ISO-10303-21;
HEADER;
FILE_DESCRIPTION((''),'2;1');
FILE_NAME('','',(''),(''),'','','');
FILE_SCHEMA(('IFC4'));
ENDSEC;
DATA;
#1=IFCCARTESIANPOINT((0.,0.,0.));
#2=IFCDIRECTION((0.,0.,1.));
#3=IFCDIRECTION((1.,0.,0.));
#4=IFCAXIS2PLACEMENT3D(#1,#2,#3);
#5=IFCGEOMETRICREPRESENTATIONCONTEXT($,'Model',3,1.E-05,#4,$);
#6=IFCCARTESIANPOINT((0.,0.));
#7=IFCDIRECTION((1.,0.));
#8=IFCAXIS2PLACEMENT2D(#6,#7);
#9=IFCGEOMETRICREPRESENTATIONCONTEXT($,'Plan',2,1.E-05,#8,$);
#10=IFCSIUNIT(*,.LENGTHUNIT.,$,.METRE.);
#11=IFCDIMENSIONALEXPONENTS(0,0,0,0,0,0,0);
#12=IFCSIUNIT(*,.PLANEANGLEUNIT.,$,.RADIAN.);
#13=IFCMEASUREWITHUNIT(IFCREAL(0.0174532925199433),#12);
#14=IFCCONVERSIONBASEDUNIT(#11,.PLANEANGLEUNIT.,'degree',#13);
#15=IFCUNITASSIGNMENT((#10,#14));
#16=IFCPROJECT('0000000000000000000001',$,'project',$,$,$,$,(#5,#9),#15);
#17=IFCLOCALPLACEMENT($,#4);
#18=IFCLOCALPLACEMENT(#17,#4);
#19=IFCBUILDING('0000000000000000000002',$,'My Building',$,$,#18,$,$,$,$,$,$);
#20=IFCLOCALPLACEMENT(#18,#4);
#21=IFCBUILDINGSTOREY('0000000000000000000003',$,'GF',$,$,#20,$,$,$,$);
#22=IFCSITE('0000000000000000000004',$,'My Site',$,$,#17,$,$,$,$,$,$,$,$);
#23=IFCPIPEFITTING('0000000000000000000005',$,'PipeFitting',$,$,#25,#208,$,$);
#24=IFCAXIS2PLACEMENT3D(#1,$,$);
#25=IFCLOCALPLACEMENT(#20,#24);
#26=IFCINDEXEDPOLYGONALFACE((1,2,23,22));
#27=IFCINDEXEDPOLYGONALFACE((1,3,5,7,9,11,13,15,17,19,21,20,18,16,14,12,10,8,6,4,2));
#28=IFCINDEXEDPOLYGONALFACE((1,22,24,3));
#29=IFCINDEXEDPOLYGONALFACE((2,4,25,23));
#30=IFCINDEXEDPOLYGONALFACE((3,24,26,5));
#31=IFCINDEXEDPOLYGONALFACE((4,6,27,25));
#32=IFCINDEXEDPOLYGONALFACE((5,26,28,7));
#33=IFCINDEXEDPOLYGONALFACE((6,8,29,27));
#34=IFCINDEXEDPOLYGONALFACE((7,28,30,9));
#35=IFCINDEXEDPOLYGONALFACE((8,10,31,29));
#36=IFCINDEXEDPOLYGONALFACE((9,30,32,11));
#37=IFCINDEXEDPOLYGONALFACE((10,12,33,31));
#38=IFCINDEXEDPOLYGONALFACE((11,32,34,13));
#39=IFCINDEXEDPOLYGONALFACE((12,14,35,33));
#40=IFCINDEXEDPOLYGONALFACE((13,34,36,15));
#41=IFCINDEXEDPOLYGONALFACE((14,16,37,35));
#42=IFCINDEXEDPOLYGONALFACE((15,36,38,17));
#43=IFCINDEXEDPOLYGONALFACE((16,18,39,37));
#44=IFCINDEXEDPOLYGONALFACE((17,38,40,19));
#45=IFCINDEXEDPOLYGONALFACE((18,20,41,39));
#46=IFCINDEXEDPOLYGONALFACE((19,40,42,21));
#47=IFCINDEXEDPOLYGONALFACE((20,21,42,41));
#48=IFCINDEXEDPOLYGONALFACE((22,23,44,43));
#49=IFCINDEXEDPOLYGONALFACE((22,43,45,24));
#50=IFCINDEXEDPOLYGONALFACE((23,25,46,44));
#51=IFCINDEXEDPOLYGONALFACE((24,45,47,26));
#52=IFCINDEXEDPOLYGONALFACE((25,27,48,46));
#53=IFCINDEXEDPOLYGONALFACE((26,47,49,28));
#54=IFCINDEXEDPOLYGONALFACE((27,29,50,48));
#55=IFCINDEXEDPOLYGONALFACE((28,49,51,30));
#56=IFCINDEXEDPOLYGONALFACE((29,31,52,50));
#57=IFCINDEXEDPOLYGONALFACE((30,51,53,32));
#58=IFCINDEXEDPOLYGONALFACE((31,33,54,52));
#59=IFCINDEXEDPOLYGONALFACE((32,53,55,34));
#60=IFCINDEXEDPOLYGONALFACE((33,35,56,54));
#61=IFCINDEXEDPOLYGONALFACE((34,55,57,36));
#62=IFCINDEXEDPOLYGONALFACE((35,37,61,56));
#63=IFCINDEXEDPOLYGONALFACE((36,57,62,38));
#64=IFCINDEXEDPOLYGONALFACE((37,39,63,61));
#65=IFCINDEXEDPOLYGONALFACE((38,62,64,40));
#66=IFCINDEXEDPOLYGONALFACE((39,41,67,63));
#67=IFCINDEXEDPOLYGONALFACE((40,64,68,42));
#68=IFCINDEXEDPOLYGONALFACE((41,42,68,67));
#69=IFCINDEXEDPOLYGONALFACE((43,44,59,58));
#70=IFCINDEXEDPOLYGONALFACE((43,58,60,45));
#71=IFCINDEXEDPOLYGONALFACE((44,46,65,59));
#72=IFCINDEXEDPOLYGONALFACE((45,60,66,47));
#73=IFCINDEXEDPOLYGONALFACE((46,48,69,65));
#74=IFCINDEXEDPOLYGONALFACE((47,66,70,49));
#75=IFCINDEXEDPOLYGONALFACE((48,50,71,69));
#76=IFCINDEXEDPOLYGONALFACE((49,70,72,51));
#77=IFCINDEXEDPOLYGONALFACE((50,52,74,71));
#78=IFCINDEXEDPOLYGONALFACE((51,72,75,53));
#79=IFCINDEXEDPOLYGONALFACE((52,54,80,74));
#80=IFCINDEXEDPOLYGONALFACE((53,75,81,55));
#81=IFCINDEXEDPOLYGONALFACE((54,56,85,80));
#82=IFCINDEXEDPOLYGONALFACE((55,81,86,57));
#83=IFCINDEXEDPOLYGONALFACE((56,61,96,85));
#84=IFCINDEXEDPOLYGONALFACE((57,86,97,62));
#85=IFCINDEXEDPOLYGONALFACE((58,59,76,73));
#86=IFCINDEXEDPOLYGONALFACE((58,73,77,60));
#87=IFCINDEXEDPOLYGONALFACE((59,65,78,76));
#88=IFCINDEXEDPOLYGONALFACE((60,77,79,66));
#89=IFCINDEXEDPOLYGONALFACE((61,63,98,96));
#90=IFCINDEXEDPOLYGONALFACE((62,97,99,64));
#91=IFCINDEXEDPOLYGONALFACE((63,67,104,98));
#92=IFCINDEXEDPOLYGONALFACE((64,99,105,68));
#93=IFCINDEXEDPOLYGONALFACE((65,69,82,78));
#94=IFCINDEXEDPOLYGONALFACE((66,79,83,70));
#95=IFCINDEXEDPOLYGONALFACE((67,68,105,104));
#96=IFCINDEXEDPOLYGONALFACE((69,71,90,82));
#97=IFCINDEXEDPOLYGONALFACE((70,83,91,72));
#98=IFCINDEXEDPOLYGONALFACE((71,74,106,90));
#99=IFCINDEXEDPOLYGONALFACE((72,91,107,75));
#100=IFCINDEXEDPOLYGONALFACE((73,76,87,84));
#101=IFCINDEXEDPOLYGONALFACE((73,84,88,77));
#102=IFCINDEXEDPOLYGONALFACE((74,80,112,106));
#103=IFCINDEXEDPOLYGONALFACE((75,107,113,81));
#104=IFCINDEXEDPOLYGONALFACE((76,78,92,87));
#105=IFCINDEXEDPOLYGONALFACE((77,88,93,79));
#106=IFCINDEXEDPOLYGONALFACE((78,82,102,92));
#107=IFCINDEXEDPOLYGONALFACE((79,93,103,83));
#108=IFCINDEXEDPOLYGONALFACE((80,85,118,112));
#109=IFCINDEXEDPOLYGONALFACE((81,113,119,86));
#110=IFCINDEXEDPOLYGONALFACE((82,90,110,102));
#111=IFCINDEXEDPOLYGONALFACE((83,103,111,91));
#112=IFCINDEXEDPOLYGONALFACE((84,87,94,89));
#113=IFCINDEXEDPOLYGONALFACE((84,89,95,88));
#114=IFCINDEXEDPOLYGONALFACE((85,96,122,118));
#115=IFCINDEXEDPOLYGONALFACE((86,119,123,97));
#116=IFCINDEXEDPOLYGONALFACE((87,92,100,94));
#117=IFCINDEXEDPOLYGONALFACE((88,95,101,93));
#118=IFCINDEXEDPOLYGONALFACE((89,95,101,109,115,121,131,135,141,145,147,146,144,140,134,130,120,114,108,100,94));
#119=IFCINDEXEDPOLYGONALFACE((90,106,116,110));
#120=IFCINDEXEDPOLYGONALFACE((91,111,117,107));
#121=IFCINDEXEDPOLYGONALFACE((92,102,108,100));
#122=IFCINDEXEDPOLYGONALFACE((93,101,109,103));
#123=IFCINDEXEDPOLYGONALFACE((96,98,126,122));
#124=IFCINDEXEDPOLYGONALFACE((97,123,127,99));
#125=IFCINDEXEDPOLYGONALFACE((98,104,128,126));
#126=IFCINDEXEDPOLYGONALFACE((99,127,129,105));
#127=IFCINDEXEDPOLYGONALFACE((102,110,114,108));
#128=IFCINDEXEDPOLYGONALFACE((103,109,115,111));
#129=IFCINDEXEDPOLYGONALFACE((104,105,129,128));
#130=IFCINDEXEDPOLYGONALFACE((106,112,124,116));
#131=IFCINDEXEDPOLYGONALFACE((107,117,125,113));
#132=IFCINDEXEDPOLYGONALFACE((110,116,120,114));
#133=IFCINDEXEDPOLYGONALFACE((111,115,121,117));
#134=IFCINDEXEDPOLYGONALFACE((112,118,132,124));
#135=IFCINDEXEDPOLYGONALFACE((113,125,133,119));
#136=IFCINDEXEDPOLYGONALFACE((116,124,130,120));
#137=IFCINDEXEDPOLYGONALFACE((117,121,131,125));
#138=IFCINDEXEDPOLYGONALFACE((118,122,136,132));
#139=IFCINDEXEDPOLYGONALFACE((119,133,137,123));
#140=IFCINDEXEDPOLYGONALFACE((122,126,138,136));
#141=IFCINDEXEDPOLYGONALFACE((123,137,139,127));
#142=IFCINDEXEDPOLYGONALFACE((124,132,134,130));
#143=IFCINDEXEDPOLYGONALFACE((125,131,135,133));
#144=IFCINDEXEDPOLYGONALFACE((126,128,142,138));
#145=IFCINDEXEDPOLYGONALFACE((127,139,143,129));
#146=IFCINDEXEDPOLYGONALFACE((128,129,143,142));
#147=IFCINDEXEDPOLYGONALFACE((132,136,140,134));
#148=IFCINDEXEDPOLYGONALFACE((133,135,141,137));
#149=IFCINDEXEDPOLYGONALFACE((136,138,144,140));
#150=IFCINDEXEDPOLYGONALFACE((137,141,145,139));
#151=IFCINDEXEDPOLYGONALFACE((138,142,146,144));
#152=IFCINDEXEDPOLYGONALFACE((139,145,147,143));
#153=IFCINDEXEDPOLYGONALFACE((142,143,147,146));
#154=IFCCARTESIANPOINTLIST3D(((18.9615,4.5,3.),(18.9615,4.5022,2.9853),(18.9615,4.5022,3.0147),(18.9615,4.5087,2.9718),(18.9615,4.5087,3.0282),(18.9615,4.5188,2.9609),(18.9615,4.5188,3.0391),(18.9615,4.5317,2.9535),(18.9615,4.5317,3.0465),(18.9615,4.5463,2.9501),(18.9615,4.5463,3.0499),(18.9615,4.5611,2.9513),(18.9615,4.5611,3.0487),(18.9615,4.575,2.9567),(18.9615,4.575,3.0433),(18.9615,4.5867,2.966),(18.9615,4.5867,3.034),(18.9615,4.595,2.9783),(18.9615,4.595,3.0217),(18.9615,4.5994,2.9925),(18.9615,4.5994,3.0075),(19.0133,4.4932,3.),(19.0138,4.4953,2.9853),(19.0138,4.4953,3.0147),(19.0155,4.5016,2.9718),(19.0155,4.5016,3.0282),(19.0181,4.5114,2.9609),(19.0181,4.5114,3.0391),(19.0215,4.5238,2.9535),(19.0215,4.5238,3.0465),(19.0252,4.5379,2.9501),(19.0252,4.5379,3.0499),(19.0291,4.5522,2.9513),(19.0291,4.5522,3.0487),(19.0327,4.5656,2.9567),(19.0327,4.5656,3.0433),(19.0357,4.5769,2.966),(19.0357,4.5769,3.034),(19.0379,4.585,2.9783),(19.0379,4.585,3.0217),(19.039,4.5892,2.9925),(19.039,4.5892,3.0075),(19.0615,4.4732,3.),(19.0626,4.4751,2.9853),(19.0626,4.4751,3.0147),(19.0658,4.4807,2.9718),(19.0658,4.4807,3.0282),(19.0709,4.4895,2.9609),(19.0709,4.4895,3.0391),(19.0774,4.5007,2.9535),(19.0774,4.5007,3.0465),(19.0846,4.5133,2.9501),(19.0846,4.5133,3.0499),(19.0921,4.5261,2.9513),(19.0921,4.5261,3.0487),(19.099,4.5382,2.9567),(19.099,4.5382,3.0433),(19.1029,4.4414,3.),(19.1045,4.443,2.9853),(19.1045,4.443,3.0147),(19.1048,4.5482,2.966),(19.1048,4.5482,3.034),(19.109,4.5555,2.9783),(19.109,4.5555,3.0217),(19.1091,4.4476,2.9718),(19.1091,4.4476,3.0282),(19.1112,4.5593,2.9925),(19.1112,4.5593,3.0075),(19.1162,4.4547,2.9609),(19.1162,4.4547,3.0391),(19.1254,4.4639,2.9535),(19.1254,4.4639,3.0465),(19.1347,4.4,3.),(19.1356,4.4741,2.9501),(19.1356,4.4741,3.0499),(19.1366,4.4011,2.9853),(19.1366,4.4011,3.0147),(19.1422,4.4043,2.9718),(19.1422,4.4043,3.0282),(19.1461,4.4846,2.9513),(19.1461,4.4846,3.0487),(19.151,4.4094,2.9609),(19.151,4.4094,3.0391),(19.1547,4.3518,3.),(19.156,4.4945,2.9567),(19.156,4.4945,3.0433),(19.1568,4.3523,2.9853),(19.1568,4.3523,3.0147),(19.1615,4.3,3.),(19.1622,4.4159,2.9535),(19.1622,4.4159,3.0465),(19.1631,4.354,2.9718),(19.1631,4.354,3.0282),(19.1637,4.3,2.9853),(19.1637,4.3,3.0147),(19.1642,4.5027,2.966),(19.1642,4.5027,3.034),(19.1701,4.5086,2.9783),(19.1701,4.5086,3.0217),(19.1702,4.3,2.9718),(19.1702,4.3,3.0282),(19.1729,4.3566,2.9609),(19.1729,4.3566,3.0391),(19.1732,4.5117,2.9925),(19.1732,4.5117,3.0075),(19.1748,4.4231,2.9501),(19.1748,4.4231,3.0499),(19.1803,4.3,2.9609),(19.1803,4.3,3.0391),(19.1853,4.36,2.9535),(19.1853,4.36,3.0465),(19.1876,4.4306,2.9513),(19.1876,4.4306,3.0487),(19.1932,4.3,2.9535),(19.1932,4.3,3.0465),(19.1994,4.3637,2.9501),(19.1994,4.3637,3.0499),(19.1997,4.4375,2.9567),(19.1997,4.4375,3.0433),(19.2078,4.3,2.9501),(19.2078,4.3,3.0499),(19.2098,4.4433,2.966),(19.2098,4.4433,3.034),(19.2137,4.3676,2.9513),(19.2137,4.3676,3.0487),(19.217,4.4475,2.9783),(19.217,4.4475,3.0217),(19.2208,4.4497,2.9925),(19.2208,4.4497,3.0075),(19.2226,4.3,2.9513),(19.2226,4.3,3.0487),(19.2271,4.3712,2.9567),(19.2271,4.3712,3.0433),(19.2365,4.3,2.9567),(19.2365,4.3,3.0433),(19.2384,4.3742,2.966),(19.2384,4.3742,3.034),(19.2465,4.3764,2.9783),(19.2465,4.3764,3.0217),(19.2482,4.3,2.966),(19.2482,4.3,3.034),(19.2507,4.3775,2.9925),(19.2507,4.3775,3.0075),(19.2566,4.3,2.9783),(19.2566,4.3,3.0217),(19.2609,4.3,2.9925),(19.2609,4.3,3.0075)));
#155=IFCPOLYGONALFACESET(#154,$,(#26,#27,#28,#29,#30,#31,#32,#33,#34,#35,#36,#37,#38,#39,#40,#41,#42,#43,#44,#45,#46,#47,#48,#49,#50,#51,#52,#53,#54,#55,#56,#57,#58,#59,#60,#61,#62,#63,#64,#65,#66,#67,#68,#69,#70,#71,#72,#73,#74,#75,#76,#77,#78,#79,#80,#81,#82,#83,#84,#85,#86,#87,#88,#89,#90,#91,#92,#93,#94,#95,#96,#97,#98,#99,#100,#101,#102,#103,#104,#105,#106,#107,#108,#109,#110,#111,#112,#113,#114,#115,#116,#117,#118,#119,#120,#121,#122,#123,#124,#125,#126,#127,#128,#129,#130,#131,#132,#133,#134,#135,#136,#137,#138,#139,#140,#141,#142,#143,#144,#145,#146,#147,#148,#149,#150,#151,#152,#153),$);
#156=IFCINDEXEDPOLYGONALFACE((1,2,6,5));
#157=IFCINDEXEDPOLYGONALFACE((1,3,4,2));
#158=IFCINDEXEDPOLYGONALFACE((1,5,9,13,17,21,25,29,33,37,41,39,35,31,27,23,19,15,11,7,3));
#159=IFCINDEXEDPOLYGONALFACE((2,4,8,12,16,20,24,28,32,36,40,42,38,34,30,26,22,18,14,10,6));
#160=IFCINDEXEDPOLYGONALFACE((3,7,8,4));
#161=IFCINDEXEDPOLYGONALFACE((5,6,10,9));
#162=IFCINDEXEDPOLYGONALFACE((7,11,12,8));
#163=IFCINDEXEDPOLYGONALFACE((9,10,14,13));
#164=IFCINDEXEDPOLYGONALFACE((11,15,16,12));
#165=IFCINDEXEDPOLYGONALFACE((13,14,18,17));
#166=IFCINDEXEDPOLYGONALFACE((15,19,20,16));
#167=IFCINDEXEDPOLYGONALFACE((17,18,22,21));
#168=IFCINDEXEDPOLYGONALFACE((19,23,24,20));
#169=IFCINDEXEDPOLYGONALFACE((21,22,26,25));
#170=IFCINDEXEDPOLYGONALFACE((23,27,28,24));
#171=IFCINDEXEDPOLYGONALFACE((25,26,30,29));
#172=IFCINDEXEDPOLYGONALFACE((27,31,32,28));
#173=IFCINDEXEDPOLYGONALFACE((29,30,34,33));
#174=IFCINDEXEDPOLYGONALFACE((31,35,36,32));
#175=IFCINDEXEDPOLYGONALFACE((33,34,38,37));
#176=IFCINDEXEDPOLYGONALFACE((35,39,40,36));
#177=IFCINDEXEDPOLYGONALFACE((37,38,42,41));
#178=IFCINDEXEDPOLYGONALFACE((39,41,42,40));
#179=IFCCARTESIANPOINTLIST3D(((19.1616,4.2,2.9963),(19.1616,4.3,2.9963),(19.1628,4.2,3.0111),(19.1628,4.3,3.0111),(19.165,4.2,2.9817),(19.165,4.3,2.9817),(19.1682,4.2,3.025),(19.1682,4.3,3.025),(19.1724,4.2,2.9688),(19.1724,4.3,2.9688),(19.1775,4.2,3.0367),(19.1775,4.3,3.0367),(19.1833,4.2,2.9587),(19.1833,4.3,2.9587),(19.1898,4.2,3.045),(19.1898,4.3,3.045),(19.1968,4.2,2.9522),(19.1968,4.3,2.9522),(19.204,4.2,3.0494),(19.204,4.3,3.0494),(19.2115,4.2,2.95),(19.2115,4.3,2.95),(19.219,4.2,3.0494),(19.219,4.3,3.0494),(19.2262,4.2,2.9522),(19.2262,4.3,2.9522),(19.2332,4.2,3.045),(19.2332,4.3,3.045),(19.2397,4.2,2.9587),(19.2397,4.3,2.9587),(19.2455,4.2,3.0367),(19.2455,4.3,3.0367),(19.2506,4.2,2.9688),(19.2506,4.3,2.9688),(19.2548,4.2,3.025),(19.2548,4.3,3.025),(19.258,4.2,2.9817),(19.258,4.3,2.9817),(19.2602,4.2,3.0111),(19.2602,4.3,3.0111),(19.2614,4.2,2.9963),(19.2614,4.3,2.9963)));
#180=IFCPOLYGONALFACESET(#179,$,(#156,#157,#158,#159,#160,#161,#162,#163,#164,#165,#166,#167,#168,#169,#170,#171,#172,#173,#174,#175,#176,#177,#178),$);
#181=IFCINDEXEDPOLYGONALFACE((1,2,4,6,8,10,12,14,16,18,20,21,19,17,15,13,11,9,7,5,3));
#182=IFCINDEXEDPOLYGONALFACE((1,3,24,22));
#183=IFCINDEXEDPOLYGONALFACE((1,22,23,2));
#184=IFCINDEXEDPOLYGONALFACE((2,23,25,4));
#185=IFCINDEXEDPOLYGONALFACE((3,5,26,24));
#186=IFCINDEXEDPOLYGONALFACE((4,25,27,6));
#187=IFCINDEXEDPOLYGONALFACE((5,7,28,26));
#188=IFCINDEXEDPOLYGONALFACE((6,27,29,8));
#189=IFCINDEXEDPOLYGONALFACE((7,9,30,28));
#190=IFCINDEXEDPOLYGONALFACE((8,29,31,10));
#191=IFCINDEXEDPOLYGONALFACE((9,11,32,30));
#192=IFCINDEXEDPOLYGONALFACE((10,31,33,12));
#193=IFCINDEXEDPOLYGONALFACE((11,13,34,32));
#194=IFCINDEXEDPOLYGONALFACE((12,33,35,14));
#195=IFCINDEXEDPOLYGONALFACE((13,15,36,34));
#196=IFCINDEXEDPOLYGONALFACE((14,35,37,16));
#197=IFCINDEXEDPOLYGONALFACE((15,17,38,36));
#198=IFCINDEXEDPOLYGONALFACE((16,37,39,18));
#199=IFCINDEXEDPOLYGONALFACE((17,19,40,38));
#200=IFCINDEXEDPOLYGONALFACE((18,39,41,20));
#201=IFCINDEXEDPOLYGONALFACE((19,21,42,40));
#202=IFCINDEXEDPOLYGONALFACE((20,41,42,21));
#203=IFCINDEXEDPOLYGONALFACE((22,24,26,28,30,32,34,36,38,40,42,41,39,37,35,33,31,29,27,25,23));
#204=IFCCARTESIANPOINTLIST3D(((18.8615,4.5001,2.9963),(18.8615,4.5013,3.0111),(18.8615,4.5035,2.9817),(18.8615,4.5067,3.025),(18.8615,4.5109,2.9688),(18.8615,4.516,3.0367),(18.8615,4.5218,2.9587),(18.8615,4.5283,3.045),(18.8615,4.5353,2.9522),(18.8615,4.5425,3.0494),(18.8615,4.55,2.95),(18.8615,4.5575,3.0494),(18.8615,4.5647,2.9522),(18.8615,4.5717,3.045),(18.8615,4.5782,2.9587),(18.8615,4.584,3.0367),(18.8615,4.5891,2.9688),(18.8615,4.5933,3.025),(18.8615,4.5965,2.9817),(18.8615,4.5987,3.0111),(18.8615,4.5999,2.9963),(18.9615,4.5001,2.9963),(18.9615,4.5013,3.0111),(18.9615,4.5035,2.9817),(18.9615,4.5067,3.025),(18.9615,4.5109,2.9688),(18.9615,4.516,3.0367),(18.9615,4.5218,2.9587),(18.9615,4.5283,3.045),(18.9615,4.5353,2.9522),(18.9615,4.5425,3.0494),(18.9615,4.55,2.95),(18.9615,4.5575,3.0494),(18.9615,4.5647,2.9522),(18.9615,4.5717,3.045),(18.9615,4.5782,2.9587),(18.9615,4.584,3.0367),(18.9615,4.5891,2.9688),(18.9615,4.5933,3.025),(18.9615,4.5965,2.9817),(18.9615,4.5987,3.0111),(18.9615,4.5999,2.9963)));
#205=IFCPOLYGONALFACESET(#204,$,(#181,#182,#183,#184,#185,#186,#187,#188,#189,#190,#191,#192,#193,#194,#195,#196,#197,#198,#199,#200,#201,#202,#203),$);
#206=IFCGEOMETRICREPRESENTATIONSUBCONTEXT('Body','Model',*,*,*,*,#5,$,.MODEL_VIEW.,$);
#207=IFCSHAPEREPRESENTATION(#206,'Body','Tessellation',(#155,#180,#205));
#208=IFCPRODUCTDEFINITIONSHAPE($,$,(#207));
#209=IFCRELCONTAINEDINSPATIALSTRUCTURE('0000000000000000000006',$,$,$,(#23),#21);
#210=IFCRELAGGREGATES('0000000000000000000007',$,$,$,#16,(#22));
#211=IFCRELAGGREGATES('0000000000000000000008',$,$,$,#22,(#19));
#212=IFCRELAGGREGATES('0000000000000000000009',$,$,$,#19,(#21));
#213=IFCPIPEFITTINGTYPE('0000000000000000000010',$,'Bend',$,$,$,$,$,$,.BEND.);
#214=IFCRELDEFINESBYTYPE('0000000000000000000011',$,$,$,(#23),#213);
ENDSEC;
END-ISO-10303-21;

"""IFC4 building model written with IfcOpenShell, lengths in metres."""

from ifc_helpers import new_model, entity, si_unit, converted_unit, frame, origin_with_axes, origin_2d_with_axis, place, context, subcontext, project, spatial, circle, extrude, source, transform, mapped, type_object, type_shapes, element, save


model = new_model("IFC4")

# Units and contexts
model_context = context("Model", 3, precision=1e-05, world=origin_with_axes())
plan_context = context("Plan", 2, precision=1e-05, world=origin_2d_with_axis())
body_context_1 = subcontext(model_context, "Body", "Model", "MODEL_VIEW")
ifc_project = project(units=[si_unit("LENGTHUNIT", "METRE"), converted_unit("PLANEANGLEUNIT", "degree", entity("IfcReal", 0.0174532925199433), si_unit("PLANEANGLEUNIT", "RADIAN"), dimensions=[0, 0, 0, 0, 0, 0, 0])], contexts=[model_context, plan_context])

# Site, building, storey
site_placement = place(None, origin_with_axes())
site = spatial("IfcSite", under=ifc_project, at=site_placement, Name="My Site")
building_placement = place(site_placement, origin_with_axes())
building = spatial("IfcBuilding", under=site, at=building_placement, Name="My Building")
storey_placement = place(building_placement, origin_with_axes())
storey = spatial("IfcBuildingStorey", under=building, at=storey_placement, Name="GF")

# Pipe fitting
pipe_fitting_type = type_object("IfcPipeFittingType", Name="Bend", PredefinedType="BEND")
shared_shape_1 = source(origin_with_axes(), body_context_1, "Body", "SolidModel", [
    entity("IfcSweptDiskSolid", entity("IfcIndexedPolyCurve", entity("IfcCartesianPointList3D", [[0.0, 0.0, -0.1], [0.0, -0.0732, -0.2768], [0.0, -0.25, -0.35]]), [entity("IfcArcIndex", [1, 2, 3])]), 0.05),
    extrude(circle(Radius=0.05), origin_with_axes(), (0.0, 0.0, -1.0), 0.1),
    extrude(circle(Radius=0.05), frame((0.0, -0.25, -0.35), z_axis=(0.0, -1.0, 0.0), x_axis=(1.0, 0.0, 0.0)), (0.0, 0.0, 1.0), 0.1),
])
type_shapes(pipe_fitting_type, [shared_shape_1])
for number, where, z_axis, x_axis, name in (
    (1, (19.2115, 4.2, 3.0), (0.0, -1.0, 0.0), (0.0, 0.0, -1.0), "PipeFitting"),
):
    element("IfcPipeFitting", number, at=place(storey_placement, frame(where, z_axis=z_axis, x_axis=x_axis)), inside=storey, type_object=pipe_fitting_type, Name=name, context=body_context_1, shape_type="MappedRepresentation", body=[
        mapped(shared_shape_1, transform((0.0, 0.0, 0.0), x_axis=(1.0, 0.0, 0.0), y_axis=(0.0, 1.0, 0.0), z_axis=(0.0, 0.0, 1.0), scale=1.0)),
    ])

save(model, "model.ifc")
